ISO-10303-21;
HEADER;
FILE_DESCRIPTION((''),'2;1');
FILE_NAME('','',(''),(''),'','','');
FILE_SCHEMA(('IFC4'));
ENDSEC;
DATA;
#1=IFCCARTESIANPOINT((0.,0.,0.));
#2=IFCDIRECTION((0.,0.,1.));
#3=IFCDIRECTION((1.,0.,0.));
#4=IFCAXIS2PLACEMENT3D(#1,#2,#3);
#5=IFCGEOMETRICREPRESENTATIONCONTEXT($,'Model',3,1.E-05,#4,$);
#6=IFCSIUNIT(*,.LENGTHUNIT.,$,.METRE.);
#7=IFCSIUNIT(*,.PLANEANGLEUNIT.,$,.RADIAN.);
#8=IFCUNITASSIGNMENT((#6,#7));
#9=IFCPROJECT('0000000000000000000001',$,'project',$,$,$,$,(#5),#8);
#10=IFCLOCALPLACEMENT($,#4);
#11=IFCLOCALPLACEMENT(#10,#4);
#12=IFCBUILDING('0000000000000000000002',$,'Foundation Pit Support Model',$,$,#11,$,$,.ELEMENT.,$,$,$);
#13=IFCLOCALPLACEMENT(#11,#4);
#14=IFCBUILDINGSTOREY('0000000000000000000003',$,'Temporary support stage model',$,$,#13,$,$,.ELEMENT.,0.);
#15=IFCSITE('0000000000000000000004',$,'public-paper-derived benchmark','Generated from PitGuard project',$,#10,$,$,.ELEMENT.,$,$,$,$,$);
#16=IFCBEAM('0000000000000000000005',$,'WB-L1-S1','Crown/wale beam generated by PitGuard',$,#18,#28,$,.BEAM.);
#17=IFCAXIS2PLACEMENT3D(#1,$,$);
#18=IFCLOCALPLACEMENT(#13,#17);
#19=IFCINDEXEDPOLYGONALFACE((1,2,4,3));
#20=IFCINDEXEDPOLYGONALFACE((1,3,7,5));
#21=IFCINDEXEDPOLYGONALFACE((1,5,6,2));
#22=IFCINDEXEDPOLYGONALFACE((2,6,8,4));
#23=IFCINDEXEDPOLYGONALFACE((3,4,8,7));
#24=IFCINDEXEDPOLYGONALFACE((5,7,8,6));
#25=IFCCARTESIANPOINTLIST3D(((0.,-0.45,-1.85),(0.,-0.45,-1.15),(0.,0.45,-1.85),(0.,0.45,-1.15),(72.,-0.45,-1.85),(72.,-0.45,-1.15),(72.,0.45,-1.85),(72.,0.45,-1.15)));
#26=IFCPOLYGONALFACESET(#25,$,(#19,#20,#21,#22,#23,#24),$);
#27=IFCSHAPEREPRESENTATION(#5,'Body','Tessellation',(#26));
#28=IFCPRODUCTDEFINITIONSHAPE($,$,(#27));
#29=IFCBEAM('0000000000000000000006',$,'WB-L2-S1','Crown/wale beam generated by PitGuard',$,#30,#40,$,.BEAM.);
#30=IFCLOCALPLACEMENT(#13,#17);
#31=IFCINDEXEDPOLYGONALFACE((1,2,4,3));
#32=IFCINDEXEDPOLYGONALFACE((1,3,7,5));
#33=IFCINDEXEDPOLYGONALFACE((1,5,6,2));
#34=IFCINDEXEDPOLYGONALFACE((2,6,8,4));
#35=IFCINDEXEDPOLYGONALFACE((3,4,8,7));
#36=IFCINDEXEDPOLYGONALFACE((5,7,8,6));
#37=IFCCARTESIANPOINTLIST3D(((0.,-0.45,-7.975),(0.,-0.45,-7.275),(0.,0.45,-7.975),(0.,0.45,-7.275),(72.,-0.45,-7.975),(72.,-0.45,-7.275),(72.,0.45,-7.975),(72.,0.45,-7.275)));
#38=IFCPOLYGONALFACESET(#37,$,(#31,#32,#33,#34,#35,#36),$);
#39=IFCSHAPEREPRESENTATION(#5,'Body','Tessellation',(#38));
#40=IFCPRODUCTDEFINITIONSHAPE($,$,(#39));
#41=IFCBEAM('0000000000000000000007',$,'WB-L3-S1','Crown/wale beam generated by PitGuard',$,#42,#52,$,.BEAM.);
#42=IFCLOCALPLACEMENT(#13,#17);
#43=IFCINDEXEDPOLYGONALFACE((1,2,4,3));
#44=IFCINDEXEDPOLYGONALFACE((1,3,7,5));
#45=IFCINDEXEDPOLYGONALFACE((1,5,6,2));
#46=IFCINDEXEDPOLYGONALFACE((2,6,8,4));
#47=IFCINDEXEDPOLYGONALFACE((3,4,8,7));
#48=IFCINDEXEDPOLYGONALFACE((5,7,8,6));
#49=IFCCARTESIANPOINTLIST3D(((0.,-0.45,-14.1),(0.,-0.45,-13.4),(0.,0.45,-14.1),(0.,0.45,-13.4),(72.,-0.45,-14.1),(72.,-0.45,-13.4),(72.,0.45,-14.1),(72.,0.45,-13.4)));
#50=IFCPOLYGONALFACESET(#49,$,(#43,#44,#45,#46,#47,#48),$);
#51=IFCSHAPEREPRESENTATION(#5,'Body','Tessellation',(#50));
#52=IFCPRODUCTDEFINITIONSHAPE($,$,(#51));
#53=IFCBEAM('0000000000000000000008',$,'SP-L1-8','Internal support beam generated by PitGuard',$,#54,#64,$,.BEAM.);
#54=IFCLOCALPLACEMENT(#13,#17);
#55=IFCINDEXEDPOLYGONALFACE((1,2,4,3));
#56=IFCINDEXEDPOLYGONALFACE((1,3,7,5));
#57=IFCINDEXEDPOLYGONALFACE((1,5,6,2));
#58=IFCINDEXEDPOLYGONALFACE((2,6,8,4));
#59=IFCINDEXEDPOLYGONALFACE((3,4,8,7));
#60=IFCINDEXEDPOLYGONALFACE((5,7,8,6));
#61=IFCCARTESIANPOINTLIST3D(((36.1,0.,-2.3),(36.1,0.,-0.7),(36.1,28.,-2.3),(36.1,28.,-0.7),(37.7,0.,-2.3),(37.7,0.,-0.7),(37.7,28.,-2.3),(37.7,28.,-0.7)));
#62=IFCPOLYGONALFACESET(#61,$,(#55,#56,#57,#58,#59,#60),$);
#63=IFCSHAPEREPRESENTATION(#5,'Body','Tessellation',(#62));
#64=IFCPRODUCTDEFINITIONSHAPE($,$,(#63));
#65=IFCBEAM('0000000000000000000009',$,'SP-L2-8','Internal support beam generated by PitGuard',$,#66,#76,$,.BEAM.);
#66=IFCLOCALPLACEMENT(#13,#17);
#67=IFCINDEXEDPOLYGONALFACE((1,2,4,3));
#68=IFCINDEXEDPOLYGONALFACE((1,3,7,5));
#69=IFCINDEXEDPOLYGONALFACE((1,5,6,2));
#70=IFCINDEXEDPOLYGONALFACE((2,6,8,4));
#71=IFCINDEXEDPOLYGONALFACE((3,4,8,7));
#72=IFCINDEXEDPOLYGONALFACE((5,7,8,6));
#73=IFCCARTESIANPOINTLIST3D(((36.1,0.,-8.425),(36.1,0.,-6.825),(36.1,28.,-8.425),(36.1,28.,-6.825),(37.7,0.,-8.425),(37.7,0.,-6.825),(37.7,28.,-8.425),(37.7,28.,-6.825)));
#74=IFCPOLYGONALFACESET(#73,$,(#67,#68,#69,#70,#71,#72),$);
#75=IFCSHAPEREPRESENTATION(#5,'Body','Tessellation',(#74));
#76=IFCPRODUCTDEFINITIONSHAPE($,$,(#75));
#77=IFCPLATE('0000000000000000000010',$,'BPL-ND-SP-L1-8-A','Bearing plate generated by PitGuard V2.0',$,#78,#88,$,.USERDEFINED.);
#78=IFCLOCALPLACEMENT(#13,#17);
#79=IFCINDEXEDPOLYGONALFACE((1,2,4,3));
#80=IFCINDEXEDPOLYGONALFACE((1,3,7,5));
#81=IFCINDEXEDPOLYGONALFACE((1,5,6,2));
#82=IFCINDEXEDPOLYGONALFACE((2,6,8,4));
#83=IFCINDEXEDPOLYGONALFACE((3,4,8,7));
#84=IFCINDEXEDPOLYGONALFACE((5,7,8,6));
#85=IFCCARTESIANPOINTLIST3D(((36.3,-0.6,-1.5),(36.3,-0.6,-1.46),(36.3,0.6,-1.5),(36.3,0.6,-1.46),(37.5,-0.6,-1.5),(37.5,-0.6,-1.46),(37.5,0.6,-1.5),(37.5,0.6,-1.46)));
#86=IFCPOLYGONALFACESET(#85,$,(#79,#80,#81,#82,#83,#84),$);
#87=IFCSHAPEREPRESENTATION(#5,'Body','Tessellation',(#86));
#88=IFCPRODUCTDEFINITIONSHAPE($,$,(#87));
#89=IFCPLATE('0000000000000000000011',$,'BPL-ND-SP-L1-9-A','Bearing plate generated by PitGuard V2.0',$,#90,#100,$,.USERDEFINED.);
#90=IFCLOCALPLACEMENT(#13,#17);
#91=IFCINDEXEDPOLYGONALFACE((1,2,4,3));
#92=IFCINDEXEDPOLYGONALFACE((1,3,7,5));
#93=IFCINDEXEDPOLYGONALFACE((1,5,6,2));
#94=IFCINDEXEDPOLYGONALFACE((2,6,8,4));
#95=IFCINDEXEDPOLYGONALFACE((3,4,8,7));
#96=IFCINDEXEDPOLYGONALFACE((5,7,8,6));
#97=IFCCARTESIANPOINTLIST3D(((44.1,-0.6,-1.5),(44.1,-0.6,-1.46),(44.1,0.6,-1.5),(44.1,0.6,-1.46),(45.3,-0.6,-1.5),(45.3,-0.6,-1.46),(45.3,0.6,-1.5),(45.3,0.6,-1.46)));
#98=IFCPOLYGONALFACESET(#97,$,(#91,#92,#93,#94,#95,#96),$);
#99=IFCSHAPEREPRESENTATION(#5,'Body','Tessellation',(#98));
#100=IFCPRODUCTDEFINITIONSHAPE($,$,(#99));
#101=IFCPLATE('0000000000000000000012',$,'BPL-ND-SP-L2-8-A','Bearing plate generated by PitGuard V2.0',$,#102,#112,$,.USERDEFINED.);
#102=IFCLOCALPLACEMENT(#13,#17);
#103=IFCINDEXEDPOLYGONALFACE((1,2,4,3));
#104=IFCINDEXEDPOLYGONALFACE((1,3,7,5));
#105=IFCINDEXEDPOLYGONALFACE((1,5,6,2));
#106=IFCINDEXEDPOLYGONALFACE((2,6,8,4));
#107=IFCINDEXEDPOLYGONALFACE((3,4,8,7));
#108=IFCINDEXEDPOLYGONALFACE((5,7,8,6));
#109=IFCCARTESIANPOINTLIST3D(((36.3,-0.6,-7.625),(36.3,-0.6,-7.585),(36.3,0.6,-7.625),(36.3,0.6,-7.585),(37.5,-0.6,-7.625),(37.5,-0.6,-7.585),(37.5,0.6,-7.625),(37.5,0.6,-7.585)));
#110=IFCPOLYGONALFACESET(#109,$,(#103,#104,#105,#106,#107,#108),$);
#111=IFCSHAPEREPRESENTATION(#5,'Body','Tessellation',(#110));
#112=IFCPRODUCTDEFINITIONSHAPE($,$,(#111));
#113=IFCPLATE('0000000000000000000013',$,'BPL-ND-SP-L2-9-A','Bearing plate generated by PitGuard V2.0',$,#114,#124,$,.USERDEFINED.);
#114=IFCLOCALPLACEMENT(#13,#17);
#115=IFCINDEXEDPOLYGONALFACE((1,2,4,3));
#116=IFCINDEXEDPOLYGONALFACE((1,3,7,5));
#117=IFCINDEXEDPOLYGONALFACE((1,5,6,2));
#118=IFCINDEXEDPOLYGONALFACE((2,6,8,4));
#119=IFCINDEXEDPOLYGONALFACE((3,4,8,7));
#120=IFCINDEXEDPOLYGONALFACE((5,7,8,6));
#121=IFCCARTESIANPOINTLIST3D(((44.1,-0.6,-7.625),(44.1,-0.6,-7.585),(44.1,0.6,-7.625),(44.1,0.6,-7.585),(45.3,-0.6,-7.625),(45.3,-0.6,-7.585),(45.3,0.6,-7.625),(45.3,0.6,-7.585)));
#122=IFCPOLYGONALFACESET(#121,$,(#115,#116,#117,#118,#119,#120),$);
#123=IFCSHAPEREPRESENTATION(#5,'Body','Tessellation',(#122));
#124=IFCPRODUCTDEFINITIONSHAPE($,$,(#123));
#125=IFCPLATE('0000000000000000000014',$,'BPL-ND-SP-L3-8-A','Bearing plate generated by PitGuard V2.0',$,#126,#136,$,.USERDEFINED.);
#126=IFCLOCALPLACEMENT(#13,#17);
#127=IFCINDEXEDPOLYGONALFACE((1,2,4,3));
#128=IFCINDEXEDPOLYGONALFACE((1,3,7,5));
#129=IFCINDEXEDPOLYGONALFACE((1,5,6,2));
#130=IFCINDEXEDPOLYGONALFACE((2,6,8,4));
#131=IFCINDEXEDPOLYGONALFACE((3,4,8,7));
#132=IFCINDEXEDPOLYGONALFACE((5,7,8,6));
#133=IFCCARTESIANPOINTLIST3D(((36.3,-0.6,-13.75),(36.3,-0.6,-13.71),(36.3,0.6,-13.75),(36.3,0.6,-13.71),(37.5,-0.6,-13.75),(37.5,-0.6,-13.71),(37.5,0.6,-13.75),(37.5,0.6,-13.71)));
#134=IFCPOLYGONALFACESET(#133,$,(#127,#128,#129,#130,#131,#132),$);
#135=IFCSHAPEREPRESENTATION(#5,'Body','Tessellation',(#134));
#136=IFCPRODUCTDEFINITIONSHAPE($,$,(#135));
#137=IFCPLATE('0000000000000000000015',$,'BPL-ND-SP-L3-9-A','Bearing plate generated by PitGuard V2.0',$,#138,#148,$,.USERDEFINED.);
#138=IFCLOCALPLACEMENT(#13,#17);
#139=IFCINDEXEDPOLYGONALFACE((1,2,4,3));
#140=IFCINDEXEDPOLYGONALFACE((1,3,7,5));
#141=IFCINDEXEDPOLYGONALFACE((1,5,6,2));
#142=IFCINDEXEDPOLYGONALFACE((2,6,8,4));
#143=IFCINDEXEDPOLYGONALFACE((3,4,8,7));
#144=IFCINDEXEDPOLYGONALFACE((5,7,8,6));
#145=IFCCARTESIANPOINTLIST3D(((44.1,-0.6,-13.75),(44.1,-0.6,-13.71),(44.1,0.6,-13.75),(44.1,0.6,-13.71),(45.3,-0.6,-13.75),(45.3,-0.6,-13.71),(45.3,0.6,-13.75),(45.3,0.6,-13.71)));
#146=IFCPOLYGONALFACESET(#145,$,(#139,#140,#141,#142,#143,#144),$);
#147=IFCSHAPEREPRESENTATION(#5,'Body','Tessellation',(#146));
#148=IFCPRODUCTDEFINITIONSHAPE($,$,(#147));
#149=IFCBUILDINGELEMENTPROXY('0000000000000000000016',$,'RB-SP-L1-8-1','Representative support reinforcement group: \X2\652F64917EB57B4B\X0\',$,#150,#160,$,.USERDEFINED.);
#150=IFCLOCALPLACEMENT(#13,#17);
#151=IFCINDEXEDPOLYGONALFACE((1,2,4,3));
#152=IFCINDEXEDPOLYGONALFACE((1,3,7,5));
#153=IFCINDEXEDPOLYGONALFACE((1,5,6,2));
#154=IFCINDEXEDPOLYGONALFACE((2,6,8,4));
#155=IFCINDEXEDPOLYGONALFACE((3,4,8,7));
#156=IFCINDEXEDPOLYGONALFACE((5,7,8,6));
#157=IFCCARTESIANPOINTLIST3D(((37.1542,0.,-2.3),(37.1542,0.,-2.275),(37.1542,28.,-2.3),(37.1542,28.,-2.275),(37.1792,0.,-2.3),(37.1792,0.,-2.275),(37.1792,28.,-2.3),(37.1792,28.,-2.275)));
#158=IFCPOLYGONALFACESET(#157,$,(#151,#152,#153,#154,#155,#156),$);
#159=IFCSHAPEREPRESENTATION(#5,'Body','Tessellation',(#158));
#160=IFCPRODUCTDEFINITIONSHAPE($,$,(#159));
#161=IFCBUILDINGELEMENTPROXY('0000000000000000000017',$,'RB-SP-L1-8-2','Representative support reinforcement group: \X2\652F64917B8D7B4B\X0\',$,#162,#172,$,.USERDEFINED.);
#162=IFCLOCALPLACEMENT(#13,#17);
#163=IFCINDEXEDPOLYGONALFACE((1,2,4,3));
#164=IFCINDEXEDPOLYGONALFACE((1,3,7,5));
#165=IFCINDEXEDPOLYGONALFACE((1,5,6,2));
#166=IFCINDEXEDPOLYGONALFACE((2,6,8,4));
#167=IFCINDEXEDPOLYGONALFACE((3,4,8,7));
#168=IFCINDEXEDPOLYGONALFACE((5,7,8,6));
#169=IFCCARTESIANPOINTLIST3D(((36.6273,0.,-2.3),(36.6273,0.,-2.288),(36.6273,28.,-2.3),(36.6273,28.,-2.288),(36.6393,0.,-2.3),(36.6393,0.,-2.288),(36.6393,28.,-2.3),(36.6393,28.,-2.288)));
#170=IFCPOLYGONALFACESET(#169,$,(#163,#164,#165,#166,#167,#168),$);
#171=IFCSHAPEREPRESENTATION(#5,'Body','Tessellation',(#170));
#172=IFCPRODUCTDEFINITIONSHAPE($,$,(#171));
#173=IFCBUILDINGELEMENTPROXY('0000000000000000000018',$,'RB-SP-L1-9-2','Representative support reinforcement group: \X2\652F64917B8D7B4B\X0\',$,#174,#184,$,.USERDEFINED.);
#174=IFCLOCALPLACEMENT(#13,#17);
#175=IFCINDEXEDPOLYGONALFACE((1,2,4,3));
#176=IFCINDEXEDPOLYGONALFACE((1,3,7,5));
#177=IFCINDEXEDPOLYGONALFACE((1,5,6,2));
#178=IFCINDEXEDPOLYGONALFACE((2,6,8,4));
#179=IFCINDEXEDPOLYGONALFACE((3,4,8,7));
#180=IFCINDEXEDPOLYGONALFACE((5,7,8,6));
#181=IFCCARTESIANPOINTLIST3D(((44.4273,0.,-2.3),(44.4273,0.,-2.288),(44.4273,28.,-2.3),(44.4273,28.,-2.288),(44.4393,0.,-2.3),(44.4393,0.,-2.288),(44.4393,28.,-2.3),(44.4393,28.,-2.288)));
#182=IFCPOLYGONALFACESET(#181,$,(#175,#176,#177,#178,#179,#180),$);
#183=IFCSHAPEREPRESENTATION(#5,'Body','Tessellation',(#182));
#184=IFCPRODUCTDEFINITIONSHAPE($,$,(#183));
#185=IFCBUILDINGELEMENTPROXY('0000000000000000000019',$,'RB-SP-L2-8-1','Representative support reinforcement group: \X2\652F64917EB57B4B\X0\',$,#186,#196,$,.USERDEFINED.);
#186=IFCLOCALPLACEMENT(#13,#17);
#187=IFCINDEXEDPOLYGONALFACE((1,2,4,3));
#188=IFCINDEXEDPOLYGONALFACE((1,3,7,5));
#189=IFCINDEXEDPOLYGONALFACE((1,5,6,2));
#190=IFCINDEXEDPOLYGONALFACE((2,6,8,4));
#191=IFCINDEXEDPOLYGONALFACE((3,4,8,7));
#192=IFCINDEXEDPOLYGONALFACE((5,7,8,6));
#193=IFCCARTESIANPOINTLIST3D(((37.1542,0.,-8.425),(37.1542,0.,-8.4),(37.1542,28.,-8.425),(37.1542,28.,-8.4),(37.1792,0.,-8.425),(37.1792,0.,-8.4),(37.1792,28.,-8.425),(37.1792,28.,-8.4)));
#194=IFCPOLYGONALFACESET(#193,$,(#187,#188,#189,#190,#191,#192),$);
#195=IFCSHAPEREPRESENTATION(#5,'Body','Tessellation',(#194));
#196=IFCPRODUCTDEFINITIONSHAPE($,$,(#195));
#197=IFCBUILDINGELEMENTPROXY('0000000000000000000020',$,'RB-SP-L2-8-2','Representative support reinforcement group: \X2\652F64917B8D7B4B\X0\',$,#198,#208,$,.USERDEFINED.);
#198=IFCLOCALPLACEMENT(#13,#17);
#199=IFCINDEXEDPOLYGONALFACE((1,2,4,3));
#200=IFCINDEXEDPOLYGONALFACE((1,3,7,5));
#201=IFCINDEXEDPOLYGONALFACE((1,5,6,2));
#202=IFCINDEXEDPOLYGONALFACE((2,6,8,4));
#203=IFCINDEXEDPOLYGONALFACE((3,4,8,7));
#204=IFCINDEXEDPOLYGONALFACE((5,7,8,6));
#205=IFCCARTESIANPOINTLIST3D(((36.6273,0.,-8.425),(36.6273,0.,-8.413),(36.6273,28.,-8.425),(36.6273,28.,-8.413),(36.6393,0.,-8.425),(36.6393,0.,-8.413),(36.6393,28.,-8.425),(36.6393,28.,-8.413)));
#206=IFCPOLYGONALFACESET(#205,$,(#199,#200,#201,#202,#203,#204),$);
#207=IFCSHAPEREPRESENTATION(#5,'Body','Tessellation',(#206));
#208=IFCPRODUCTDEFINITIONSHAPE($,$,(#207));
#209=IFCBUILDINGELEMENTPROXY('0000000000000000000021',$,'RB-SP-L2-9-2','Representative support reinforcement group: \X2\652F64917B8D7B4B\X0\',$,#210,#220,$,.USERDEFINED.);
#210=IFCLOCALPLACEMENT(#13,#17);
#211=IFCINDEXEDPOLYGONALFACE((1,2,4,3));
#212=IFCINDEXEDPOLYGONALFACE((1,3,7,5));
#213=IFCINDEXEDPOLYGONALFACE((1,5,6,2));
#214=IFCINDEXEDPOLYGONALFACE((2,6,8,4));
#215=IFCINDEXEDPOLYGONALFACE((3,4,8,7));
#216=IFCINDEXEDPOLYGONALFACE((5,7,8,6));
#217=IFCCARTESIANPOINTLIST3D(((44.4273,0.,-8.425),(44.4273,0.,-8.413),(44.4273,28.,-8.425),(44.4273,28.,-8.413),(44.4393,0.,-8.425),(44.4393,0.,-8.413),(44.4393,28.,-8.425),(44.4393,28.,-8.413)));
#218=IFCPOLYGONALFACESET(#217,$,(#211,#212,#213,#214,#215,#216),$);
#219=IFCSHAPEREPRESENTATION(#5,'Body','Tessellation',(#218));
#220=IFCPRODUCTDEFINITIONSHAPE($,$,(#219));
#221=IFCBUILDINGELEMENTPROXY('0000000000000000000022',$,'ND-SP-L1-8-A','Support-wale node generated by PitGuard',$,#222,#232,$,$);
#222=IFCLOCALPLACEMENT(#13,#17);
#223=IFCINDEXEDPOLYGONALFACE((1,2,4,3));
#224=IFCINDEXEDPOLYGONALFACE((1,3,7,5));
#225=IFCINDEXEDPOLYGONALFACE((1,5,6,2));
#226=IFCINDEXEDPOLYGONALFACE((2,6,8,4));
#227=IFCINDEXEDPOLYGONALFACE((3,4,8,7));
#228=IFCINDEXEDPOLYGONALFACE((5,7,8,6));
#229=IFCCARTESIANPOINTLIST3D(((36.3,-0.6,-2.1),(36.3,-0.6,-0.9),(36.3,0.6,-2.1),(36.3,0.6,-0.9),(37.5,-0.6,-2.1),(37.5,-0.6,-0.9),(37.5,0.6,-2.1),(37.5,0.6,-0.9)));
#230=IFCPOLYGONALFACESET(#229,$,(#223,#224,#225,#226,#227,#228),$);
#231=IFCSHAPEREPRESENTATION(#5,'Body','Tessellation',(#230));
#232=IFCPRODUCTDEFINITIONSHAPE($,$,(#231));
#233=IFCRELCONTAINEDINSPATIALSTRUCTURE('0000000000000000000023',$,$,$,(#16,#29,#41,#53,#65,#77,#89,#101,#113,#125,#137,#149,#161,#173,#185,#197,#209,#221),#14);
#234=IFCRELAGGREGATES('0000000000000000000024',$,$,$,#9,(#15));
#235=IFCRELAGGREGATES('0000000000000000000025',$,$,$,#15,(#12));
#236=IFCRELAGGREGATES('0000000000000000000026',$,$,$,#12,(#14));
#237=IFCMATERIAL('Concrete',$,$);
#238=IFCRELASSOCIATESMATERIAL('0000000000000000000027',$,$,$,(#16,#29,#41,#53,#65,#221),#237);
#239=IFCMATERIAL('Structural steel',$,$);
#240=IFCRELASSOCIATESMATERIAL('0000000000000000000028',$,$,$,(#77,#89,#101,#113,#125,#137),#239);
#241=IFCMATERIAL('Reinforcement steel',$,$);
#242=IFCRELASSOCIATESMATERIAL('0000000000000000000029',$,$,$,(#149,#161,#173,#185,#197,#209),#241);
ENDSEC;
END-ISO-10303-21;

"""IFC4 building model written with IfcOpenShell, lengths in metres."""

from ifc_helpers import new_model, si_unit, frame, origin_with_axes, origin_2d, place, context, project, spatial, rectangle, extrude, material, element, save


model = new_model("IFC4")

# Units and contexts
model_context = context("Model", 3, precision=1e-05, world=origin_with_axes())
ifc_project = project(units=[si_unit("LENGTHUNIT", "METRE"), si_unit("PLANEANGLEUNIT", "RADIAN")], contexts=[model_context])

# Site, building, storey
site_placement = place(None, origin_with_axes())
site = spatial("IfcSite", under=ifc_project, at=site_placement, Name="public-paper-derived benchmark", Description="Generated from PitGuard project", CompositionType="ELEMENT")
building_placement = place(site_placement, origin_with_axes())
building = spatial("IfcBuilding", under=site, at=building_placement, Name="Foundation Pit Support Model", CompositionType="ELEMENT")
storey_placement = place(building_placement, origin_with_axes())
storey = spatial("IfcBuildingStorey", under=building, at=storey_placement, Name="Temporary support stage model", CompositionType="ELEMENT", Elevation=0.0)

# Beams
ifc_material_1 = material(Name="Concrete")
for number, where, z_axis, x_axis, name in (
    (1, (36.0, 0.0, -1.85), (0.0, 0.0, 1.0), (1.0, 0.0, 0.0), "WB-L1-S1"),
    (2, (36.0, 0.0, -7.975), (0.0, 0.0, 1.0), (1.0, 0.0, 0.0), "WB-L2-S1"),
    (3, (36.0, 0.0, -14.1), (0.0, 0.0, 1.0), (1.0, 0.0, 0.0), "WB-L3-S1"),
):
    element("IfcBeam", number, at=place(storey_placement, frame(where, z_axis=z_axis, x_axis=x_axis)), inside=storey, material=ifc_material_1, Name=name, Description="Crown/wale beam generated by PitGuard", PredefinedType="BEAM", context=model_context, shape_type="SweptSolid", body=[
        extrude(rectangle(XDim=72.0, YDim=0.9, at=origin_2d()), origin_with_axes(), (0.0, 0.0, 1.0), 0.7),
    ])
for number, where, z_axis, x_axis, name in (
    (4, (36.9, 14.0, -2.3), (0.0, 0.0, 1.0), (0.0, 1.0, 0.0), "SP-L1-8"),
    (5, (36.9, 14.0, -8.425), (0.0, 0.0, 1.0), (0.0, 1.0, 0.0), "SP-L2-8"),
):
    element("IfcBeam", number, at=place(storey_placement, frame(where, z_axis=z_axis, x_axis=x_axis)), inside=storey, material=ifc_material_1, Name=name, Description="Internal support beam generated by PitGuard", PredefinedType="BEAM", context=model_context, shape_type="SweptSolid", body=[
        extrude(rectangle(XDim=28.0, YDim=1.6, at=origin_2d()), origin_with_axes(), (0.0, 0.0, 1.0), 1.6),
    ])

# Plates
ifc_material_2 = material(Name="Structural steel")
for number, where, z_axis, x_axis, name in (
    (6, (36.9, 0.0, -1.5), (0.0, 0.0, 1.0), (1.0, 0.0, 0.0), "BPL-ND-SP-L1-8-A"),
    (7, (44.7, 0.0, -1.5), (0.0, 0.0, 1.0), (1.0, 0.0, 0.0), "BPL-ND-SP-L1-9-A"),
    (8, (36.9, 0.0, -7.625), (0.0, 0.0, 1.0), (1.0, 0.0, 0.0), "BPL-ND-SP-L2-8-A"),
    (9, (44.7, 0.0, -7.625), (0.0, 0.0, 1.0), (1.0, 0.0, 0.0), "BPL-ND-SP-L2-9-A"),
    (10, (36.9, 0.0, -13.75), (0.0, 0.0, 1.0), (1.0, 0.0, 0.0), "BPL-ND-SP-L3-8-A"),
    (11, (44.7, 0.0, -13.75), (0.0, 0.0, 1.0), (1.0, 0.0, 0.0), "BPL-ND-SP-L3-9-A"),
):
    element("IfcPlate", number, at=place(storey_placement, frame(where, z_axis=z_axis, x_axis=x_axis)), inside=storey, material=ifc_material_2, Name=name, Description="Bearing plate generated by PitGuard V2.0", PredefinedType="USERDEFINED", context=model_context, shape_type="SweptSolid", body=[
        extrude(rectangle(XDim=1.2, YDim=1.2, at=origin_2d()), origin_with_axes(), (0.0, 0.0, 1.0), 0.04),
    ])

# Building element proxies
ifc_material_3 = material(Name="Reinforcement steel")
proxy_1_placement = place(storey_placement, frame((37.1667, 14.0, -2.3), z_axis=(0.0, 0.0, 1.0), x_axis=(0.0, 1.0, 0.0)))
element("IfcBuildingElementProxy", 12, at=proxy_1_placement, inside=storey, material=ifc_material_3, Name="RB-SP-L1-8-1", Description="Representative support reinforcement group: 支撑纵筋", PredefinedType="USERDEFINED", context=model_context, shape_type="SweptSolid", body=[
    extrude(rectangle(XDim=28.0, YDim=0.025, at=origin_2d()), origin_with_axes(), (0.0, 0.0, 1.0), 0.025),
])
for number, where, z_axis, x_axis, name in (
    (13, (36.6333, 14.0, -2.3), (0.0, 0.0, 1.0), (0.0, 1.0, 0.0), "RB-SP-L1-8-2"),
    (14, (44.4333, 14.0, -2.3), (0.0, 0.0, 1.0), (0.0, 1.0, 0.0), "RB-SP-L1-9-2"),
):
    element("IfcBuildingElementProxy", number, at=place(storey_placement, frame(where, z_axis=z_axis, x_axis=x_axis)), inside=storey, material=ifc_material_3, Name=name, Description="Representative support reinforcement group: 支撑箍筋", PredefinedType="USERDEFINED", context=model_context, shape_type="SweptSolid", body=[
        extrude(rectangle(XDim=28.0, YDim=0.012, at=origin_2d()), origin_with_axes(), (0.0, 0.0, 1.0), 0.012),
    ])
proxy_2_placement = place(storey_placement, frame((37.1667, 14.0, -8.425), z_axis=(0.0, 0.0, 1.0), x_axis=(0.0, 1.0, 0.0)))
element("IfcBuildingElementProxy", 15, at=proxy_2_placement, inside=storey, material=ifc_material_3, Name="RB-SP-L2-8-1", Description="Representative support reinforcement group: 支撑纵筋", PredefinedType="USERDEFINED", context=model_context, shape_type="SweptSolid", body=[
    extrude(rectangle(XDim=28.0, YDim=0.025, at=origin_2d()), origin_with_axes(), (0.0, 0.0, 1.0), 0.025),
])
for number, where, z_axis, x_axis, name in (
    (16, (36.6333, 14.0, -8.425), (0.0, 0.0, 1.0), (0.0, 1.0, 0.0), "RB-SP-L2-8-2"),
    (17, (44.4333, 14.0, -8.425), (0.0, 0.0, 1.0), (0.0, 1.0, 0.0), "RB-SP-L2-9-2"),
):
    element("IfcBuildingElementProxy", number, at=place(storey_placement, frame(where, z_axis=z_axis, x_axis=x_axis)), inside=storey, material=ifc_material_3, Name=name, Description="Representative support reinforcement group: 支撑箍筋", PredefinedType="USERDEFINED", context=model_context, shape_type="SweptSolid", body=[
        extrude(rectangle(XDim=28.0, YDim=0.012, at=origin_2d()), origin_with_axes(), (0.0, 0.0, 1.0), 0.012),
    ])
proxy_3_placement = place(storey_placement, frame((36.9, 0.0, -2.1), z_axis=(0.0, 0.0, 1.0), x_axis=(1.0, 0.0, 0.0)))
element("IfcBuildingElementProxy", 18, at=proxy_3_placement, inside=storey, material=ifc_material_1, Name="ND-SP-L1-8-A", Description="Support-wale node generated by PitGuard", context=model_context, shape_type="SweptSolid", body=[
    extrude(rectangle(XDim=1.2, YDim=1.2, at=origin_2d()), origin_with_axes(), (0.0, 0.0, 1.0), 1.2),
])

save(model, "model.ifc")
